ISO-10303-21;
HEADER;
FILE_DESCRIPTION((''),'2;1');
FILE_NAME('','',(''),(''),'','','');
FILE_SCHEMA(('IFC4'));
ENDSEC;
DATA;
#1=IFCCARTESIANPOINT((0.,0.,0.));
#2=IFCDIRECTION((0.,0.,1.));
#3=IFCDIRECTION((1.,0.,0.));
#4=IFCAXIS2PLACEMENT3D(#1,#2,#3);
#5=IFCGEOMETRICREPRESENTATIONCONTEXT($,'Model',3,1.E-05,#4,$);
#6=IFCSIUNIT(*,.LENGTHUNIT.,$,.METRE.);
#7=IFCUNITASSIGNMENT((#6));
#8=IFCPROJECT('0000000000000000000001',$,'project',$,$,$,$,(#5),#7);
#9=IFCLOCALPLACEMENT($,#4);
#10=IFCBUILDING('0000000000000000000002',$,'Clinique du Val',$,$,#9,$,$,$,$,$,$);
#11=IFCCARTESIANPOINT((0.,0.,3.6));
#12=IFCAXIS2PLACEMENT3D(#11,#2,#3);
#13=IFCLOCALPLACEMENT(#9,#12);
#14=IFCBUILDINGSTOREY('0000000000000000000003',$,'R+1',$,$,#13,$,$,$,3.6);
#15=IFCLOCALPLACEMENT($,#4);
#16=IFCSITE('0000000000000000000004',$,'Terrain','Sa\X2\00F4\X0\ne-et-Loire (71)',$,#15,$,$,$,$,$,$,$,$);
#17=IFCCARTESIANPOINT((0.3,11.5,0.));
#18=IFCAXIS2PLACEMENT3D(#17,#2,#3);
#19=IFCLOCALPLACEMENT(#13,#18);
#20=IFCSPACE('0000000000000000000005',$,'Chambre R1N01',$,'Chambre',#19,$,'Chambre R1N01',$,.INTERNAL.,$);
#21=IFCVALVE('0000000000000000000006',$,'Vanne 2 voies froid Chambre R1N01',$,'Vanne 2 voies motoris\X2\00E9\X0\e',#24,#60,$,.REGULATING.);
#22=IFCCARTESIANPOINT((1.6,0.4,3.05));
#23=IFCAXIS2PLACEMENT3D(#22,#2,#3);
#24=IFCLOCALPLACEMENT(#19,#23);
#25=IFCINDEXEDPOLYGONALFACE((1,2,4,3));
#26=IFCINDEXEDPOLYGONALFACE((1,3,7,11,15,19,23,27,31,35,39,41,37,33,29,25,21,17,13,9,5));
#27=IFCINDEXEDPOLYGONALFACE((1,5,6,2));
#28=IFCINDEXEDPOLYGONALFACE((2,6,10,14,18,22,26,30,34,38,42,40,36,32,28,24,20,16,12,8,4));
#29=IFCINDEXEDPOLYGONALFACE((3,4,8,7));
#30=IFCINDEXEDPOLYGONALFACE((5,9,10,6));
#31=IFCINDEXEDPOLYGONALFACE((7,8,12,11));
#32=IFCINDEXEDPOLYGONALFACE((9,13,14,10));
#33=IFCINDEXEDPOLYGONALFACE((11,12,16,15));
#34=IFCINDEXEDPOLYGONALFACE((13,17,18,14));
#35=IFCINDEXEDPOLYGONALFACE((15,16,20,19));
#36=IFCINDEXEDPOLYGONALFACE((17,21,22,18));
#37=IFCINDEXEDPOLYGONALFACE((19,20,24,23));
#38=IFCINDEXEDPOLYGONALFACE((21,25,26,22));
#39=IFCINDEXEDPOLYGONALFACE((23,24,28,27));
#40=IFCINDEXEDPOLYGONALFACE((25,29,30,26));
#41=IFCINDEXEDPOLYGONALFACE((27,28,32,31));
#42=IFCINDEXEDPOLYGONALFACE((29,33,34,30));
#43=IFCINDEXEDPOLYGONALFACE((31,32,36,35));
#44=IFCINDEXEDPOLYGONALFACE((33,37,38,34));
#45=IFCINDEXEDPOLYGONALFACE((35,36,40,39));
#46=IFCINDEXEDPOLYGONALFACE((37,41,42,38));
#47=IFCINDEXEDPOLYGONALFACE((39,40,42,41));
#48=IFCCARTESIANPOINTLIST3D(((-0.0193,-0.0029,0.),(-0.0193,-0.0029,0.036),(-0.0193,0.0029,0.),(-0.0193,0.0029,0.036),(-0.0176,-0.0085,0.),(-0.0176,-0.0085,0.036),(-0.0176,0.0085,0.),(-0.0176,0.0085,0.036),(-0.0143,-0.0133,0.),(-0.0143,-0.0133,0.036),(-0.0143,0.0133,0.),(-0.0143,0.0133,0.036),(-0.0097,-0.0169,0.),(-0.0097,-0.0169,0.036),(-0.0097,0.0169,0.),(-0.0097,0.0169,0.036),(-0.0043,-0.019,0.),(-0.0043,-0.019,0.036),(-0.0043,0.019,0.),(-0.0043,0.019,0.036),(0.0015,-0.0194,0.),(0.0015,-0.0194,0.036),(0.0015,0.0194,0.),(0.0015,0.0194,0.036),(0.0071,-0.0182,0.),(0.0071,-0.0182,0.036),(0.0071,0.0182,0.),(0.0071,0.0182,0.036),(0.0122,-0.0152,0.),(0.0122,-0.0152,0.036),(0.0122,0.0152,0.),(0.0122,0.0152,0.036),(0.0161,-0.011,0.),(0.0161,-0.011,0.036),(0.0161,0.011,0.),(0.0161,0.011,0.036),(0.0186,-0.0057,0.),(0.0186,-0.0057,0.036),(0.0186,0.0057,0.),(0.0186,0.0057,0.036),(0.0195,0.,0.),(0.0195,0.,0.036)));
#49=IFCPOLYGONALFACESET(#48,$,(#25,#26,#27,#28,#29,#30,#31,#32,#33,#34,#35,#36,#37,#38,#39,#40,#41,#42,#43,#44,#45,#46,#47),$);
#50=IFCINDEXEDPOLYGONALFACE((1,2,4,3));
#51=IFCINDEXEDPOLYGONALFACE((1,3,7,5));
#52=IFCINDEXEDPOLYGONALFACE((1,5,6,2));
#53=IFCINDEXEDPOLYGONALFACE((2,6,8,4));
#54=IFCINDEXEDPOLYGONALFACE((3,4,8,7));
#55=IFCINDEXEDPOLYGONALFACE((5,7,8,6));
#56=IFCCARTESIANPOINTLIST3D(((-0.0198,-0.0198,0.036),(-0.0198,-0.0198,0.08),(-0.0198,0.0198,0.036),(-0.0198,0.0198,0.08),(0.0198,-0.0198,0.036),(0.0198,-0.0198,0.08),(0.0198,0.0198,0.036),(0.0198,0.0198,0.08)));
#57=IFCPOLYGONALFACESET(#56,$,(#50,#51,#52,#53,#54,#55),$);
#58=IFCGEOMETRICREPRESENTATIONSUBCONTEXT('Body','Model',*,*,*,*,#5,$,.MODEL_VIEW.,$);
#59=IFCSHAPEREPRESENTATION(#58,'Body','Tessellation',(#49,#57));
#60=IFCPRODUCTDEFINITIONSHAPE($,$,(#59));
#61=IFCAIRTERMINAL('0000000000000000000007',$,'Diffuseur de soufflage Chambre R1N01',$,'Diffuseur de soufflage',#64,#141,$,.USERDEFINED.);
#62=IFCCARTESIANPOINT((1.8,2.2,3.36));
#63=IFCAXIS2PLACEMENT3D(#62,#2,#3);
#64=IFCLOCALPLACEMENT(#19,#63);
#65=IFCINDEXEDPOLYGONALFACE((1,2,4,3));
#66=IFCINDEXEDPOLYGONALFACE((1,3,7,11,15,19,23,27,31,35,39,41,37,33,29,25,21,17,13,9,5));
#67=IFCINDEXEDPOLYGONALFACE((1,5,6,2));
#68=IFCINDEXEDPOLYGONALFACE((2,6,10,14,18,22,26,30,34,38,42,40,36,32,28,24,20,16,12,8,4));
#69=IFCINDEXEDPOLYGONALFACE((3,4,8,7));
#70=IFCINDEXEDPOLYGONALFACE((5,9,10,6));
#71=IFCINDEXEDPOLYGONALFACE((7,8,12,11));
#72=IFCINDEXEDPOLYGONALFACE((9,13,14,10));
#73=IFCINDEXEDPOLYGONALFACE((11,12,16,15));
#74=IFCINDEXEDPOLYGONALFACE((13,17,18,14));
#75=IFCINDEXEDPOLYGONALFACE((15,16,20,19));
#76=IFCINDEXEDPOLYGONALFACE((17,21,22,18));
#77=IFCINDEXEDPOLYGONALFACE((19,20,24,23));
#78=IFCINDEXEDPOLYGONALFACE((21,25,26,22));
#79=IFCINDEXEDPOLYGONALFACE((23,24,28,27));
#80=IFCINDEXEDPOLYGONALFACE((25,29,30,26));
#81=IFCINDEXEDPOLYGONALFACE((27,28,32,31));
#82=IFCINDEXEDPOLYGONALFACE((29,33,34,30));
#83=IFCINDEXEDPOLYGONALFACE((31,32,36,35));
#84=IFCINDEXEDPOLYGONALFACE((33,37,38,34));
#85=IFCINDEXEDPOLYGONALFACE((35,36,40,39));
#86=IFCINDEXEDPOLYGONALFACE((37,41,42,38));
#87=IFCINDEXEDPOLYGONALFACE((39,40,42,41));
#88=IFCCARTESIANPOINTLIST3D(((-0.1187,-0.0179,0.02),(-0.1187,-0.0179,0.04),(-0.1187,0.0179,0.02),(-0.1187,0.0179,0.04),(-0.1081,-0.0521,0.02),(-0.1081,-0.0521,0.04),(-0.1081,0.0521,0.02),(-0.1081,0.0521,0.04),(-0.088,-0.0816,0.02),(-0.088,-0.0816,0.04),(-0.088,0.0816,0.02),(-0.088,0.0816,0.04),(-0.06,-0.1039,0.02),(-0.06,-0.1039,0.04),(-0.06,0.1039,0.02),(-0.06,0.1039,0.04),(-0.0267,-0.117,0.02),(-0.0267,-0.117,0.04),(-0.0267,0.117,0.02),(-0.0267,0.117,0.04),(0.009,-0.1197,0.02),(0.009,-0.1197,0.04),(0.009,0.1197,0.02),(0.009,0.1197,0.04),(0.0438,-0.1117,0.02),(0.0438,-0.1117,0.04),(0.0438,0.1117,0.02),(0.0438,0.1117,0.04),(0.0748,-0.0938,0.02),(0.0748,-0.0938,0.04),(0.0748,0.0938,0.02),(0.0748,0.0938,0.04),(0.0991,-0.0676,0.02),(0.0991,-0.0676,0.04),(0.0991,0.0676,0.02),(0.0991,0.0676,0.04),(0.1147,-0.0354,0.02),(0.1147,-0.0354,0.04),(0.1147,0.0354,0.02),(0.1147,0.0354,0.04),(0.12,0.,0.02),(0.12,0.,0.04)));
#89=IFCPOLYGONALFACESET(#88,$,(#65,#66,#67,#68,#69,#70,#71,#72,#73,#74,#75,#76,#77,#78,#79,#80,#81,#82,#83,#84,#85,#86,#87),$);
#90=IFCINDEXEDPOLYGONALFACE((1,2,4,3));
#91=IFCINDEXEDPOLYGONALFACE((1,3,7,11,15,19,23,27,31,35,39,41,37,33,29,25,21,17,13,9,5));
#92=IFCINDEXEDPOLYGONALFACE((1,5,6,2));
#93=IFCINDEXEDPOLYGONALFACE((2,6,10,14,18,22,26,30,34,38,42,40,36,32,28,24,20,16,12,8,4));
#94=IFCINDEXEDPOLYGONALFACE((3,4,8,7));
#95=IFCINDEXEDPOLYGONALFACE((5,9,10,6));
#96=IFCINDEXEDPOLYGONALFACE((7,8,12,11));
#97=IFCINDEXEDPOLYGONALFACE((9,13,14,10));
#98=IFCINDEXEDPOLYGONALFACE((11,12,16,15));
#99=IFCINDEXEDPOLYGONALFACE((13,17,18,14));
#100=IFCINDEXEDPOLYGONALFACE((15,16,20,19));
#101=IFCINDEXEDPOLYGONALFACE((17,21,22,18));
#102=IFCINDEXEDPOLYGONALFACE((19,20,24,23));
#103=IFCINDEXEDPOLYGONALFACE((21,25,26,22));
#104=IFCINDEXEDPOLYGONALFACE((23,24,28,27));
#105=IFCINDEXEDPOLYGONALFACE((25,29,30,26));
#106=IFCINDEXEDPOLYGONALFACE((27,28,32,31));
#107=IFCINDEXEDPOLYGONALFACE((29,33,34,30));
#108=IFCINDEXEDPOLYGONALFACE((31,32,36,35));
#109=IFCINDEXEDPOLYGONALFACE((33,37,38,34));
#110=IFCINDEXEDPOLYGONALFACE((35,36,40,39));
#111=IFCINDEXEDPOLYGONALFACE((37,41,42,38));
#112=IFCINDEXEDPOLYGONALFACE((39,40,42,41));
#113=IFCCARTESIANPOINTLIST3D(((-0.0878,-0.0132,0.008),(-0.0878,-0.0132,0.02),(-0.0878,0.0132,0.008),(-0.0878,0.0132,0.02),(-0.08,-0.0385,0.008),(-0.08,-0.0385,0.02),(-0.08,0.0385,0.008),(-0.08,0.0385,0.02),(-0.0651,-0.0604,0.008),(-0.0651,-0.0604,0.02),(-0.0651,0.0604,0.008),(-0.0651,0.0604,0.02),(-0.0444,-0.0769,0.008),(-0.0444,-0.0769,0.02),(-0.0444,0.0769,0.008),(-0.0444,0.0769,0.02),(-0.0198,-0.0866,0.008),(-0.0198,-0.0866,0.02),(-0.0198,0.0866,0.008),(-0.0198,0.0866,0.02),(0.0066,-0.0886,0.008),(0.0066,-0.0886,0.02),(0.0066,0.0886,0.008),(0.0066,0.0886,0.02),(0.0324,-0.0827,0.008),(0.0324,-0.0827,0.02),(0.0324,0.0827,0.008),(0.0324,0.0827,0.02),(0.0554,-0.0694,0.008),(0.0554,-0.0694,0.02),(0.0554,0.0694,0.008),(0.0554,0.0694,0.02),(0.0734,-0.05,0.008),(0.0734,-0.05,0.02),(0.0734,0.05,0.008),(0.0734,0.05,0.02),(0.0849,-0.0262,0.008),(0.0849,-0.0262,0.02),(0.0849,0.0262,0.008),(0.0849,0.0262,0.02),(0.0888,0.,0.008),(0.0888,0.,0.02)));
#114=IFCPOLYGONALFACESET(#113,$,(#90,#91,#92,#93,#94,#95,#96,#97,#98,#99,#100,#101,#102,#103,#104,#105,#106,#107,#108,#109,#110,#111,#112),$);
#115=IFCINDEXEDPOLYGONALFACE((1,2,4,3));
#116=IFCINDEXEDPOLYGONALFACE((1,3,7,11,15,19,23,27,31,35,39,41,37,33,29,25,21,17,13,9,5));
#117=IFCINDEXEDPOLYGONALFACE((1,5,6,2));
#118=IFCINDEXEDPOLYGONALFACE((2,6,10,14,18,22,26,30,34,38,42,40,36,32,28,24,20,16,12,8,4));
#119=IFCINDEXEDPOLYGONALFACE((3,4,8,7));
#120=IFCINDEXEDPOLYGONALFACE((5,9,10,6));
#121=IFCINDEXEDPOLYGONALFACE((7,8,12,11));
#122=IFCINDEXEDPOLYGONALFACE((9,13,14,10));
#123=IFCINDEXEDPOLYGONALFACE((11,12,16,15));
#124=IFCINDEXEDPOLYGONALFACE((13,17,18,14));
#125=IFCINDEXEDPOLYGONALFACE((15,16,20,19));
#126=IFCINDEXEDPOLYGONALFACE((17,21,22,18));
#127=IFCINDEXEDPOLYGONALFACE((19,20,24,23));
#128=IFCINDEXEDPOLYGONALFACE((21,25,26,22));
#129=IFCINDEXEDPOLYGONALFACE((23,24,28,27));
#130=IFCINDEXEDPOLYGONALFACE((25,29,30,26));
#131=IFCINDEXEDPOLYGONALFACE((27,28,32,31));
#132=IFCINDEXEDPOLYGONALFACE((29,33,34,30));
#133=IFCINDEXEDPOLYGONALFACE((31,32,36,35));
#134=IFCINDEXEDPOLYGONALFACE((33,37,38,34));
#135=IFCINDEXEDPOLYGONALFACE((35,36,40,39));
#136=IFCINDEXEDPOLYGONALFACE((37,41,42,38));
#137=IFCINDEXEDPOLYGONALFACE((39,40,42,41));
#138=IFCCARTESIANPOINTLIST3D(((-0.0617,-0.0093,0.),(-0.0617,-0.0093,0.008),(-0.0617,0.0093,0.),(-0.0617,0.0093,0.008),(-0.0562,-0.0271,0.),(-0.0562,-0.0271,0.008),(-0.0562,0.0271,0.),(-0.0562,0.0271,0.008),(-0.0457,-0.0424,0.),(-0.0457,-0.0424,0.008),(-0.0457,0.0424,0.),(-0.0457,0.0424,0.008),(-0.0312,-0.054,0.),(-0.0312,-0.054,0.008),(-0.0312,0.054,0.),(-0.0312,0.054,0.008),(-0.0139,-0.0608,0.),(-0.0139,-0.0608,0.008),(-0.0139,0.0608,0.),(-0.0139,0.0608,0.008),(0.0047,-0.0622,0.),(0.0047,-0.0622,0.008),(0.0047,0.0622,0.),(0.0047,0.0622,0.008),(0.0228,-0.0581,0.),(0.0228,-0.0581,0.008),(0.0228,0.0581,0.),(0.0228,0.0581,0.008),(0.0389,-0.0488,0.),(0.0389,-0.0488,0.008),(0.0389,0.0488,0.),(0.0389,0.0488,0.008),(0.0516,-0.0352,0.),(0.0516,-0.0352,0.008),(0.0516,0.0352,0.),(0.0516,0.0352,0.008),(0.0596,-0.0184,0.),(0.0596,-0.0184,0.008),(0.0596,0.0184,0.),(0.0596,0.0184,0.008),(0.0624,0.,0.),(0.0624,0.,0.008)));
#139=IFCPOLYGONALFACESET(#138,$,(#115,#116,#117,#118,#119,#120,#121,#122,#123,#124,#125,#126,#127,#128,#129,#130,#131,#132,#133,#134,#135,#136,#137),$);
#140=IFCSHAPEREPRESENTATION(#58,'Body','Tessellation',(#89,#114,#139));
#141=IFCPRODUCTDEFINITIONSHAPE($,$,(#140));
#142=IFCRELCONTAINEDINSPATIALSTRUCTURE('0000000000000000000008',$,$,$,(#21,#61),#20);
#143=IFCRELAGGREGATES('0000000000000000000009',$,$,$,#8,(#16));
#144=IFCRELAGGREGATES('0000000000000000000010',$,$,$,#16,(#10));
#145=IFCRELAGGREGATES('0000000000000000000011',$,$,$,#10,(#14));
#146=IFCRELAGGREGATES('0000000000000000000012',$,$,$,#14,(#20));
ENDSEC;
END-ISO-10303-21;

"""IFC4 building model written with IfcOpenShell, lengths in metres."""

from ifc_helpers import new_model, si_unit, frame, frame_2d, origin_with_axes, place, context, subcontext, project, spatial, rectangle, circle, extrude, element, save


model = new_model("IFC4")

# Units and contexts
model_context = context("Model", 3, precision=1e-05, world=origin_with_axes())
body_context = subcontext(model_context, "Body", "Model", "MODEL_VIEW")
ifc_project = project(units=[si_unit("LENGTHUNIT", "METRE")], contexts=[model_context])

# Site, building, storey
site_placement = place(None, origin_with_axes())
site = spatial("IfcSite", under=ifc_project, at=site_placement, Name="Terrain", Description="Saône-et-Loire (71)")
building_placement = place(None, origin_with_axes())
building = spatial("IfcBuilding", under=site, at=building_placement, Name="Clinique du Val")
storey_placement = place(building_placement, frame((0.0, 0.0, 3.6), z_axis=(0.0, 0.0, 1.0), x_axis=(1.0, 0.0, 0.0)))
storey = spatial("IfcBuildingStorey", under=building, at=storey_placement, Name="R+1", Elevation=3.6)

# Shared definitions
space_placement = place(storey_placement, frame((0.3, 11.5, 0.0), z_axis=(0.0, 0.0, 1.0), x_axis=(1.0, 0.0, 0.0)))
space = spatial("IfcSpace", under=storey, at=space_placement, Name="Chambre R1N01", ObjectType="Chambre", LongName="Chambre R1N01", PredefinedType="INTERNAL")

# Valve
valve_placement = place(space_placement, frame((1.6, 0.4, 3.05), z_axis=(0.0, 0.0, 1.0), x_axis=(1.0, 0.0, 0.0)))
element("IfcValve", 1, at=valve_placement, inside=space, Name="Vanne 2 voies froid Chambre R1N01", ObjectType="Vanne 2 voies motorisée", PredefinedType="REGULATING", context=body_context, shape_type="SweptSolid", body=[
    extrude(circle(Radius=0.0195), origin_with_axes(), (0.0, 0.0, 1.0), 0.036),
    extrude(rectangle(XDim=0.0396, YDim=0.0396, at=frame_2d((0.0198, 0.0198))), frame((-0.0198, -0.0198, 0.036), z_axis=(0.0, 0.0, 1.0), x_axis=(1.0, 0.0, 0.0)), (0.0, 0.0, 1.0), 0.044),
])

# Air terminal
air_terminal_placement = place(space_placement, frame((1.8, 2.2, 3.36), z_axis=(0.0, 0.0, 1.0), x_axis=(1.0, 0.0, 0.0)))
element("IfcAirTerminal", 2, at=air_terminal_placement, inside=space, Name="Diffuseur de soufflage Chambre R1N01", ObjectType="Diffuseur de soufflage", PredefinedType="USERDEFINED", context=body_context, shape_type="SweptSolid", body=[
    extrude(circle(Radius=0.12), frame((0.0, 0.0, 0.02), z_axis=(0.0, 0.0, 1.0), x_axis=(1.0, 0.0, 0.0)), (0.0, 0.0, 1.0), 0.02),
    extrude(circle(Radius=0.0888), frame((0.0, 0.0, 0.008), z_axis=(0.0, 0.0, 1.0), x_axis=(1.0, 0.0, 0.0)), (0.0, 0.0, 1.0), 0.012),
    extrude(circle(Radius=0.0624), origin_with_axes(), (0.0, 0.0, 1.0), 0.008),
])

save(model, "model.ifc")
